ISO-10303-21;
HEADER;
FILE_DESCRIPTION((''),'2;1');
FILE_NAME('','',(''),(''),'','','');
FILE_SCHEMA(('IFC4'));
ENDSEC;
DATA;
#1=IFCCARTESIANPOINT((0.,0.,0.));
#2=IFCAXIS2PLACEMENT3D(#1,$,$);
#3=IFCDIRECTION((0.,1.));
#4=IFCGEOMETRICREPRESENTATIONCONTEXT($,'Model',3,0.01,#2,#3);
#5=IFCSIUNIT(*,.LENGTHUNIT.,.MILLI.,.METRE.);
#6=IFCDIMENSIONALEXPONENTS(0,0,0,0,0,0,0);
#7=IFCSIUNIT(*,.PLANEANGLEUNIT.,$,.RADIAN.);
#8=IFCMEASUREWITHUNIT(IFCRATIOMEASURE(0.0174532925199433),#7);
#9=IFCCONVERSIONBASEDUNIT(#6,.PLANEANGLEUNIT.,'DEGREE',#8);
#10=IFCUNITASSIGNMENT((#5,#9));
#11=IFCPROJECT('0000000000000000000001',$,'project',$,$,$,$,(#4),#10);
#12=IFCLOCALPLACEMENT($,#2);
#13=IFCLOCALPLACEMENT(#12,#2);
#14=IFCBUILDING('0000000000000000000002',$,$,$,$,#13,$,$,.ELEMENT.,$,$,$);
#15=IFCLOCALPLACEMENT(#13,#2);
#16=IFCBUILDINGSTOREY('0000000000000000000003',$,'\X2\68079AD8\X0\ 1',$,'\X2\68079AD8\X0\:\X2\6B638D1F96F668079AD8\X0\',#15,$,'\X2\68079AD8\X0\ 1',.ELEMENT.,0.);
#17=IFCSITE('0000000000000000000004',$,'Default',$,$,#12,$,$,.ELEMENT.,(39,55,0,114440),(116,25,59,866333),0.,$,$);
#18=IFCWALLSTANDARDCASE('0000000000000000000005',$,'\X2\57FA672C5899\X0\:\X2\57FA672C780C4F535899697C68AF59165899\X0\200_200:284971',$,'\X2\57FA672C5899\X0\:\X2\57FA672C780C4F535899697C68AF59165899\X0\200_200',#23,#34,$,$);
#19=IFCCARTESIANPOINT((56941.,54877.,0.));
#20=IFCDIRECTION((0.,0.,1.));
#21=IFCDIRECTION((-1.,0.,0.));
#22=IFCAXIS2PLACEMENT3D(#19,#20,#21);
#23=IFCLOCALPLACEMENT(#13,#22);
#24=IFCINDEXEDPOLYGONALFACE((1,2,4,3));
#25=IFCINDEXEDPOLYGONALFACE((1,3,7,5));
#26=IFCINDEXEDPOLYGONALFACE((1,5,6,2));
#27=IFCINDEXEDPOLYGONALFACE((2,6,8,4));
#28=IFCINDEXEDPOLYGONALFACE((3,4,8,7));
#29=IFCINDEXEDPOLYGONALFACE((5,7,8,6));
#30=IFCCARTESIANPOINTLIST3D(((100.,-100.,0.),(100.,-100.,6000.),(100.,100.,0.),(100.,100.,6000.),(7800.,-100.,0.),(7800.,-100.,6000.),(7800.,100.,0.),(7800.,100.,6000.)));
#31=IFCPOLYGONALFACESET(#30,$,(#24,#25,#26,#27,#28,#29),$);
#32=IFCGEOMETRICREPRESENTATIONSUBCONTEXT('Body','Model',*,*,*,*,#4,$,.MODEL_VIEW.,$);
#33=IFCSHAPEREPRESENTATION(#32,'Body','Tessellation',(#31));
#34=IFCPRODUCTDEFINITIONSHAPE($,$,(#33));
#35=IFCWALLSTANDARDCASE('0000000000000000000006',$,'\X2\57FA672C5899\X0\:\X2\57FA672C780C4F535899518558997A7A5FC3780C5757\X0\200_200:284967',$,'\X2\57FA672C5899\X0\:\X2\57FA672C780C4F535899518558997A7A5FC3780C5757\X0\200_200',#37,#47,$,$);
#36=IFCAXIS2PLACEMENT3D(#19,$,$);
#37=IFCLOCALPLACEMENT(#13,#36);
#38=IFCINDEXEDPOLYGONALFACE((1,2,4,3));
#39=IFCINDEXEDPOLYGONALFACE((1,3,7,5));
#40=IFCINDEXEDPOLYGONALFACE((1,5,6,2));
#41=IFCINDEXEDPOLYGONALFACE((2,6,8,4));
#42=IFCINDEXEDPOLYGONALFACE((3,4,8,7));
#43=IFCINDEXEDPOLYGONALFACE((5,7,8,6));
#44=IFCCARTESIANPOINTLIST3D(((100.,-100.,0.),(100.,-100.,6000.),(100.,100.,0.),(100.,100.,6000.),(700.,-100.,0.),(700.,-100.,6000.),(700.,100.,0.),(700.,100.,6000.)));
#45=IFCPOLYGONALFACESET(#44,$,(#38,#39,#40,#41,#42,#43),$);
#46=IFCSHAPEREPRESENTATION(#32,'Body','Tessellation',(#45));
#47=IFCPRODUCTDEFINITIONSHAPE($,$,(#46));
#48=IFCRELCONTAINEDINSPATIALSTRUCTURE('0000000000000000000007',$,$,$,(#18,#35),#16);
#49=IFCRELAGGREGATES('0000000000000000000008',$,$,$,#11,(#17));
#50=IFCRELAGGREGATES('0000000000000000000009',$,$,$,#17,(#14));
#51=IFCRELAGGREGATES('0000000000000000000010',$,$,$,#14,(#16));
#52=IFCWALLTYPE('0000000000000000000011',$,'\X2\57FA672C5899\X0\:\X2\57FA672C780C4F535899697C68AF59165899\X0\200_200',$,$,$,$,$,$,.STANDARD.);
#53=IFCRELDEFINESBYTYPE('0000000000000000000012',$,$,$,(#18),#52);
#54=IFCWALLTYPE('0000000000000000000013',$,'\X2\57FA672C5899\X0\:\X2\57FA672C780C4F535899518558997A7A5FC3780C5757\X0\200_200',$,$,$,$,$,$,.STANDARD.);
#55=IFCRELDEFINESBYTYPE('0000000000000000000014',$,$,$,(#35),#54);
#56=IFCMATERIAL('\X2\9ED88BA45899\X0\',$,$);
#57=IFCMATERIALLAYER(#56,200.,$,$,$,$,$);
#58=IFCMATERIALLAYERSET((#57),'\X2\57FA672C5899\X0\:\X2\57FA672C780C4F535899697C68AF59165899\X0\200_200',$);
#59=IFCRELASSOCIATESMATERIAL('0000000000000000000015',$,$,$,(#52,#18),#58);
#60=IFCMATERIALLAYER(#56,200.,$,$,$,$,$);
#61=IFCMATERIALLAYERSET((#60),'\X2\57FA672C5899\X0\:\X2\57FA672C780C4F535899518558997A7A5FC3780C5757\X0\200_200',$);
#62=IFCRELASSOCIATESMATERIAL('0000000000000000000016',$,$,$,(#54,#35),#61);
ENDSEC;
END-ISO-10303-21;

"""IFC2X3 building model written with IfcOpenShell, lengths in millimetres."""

from ifc_helpers import new_model, entity, si_unit, converted_unit, direction, frame, frame_2d, origin, place, context, subcontext, project, spatial, rectangle, extrude, material, layer, layer_set, layer_usage, type_object, element, save


model = new_model("IFC2X3")

# Units and contexts
model_context = context("Model", 3, precision=0.01, world=origin(), true_north=direction((0.0, 1.0)))
body_context = subcontext(model_context, "Body", "Model", "MODEL_VIEW")
ifc_project = project(units=[si_unit("LENGTHUNIT", "METRE", prefix="MILLI"), converted_unit("PLANEANGLEUNIT", "DEGREE", entity("IfcRatioMeasure", 0.0174532925199433), si_unit("PLANEANGLEUNIT", "RADIAN"), dimensions=[0, 0, 0, 0, 0, 0, 0])], contexts=[model_context])

# Site, building, storey
site_placement = place(None, origin())
site = spatial("IfcSite", under=ifc_project, at=site_placement, Name="Default", CompositionType="ELEMENT", RefLatitude=(39, 55, 0, 114440), RefLongitude=(116, 25, 59, 866333), RefElevation=0.0)
building_placement = place(site_placement, origin())
building = spatial("IfcBuilding", under=site, at=building_placement, CompositionType="ELEMENT")
storey_placement = place(building_placement, origin())
storey = spatial("IfcBuildingStorey", under=building, at=storey_placement, Name="标高 1", ObjectType="标高:正负零标高", LongName="标高 1", CompositionType="ELEMENT", Elevation=0.0)

# Walls
ifc_material = material(Name="默认墙")
ifc_layer_1 = layer(ifc_material, 200.0)
ifc_layer_set_1 = layer_set([ifc_layer_1], Name="基本墙:基本砌体墙楼梯外墙200_200")
wall_type_1 = type_object("IfcWallType", Name="基本墙:基本砌体墙楼梯外墙200_200", PredefinedType="STANDARD", material=ifc_layer_set_1)
ifc_layer_usage_1 = layer_usage(ifc_layer_set_1, "AXIS2", "NEGATIVE", 100.0)
wall_1_placement = place(building_placement, frame((56941.0, 54877.0, 0.0), z_axis=(0.0, 0.0, 1.0), x_axis=(-1.0, 0.0, 0.0)))
element("IfcWallStandardCase", 1, at=wall_1_placement, inside=storey, type_object=wall_type_1, material=ifc_layer_usage_1, Name="基本墙:基本砌体墙楼梯外墙200_200:284971", ObjectType="基本墙:基本砌体墙楼梯外墙200_200", context=body_context, shape_type="SweptSolid", body=[
    extrude(rectangle(XDim=7700.0, YDim=200.0, at=frame_2d((3950.0, 0.0), x_axis=(-1.0, 0.0))), origin(), (0.0, 0.0, 1.0), 6000.0),
])
ifc_layer_2 = layer(ifc_material, 200.0)
ifc_layer_set_2 = layer_set([ifc_layer_2], Name="基本墙:基本砌体墙内墙空心砌块200_200")
wall_type_2 = type_object("IfcWallType", Name="基本墙:基本砌体墙内墙空心砌块200_200", PredefinedType="STANDARD", material=ifc_layer_set_2)
ifc_layer_usage_2 = layer_usage(ifc_layer_set_2, "AXIS2", "NEGATIVE", 100.0)
wall_2_placement = place(building_placement, frame((56941.0, 54877.0, 0.0)))
element("IfcWallStandardCase", 2, at=wall_2_placement, inside=storey, type_object=wall_type_2, material=ifc_layer_usage_2, Name="基本墙:基本砌体墙内墙空心砌块200_200:284967", ObjectType="基本墙:基本砌体墙内墙空心砌块200_200", context=body_context, shape_type="SweptSolid", body=[
    extrude(rectangle(XDim=600.0, YDim=200.0, at=frame_2d((400.0, 0.0), x_axis=(-1.0, 0.0))), origin(), (0.0, 0.0, 1.0), 6000.0),
])

save(model, "model.ifc")
